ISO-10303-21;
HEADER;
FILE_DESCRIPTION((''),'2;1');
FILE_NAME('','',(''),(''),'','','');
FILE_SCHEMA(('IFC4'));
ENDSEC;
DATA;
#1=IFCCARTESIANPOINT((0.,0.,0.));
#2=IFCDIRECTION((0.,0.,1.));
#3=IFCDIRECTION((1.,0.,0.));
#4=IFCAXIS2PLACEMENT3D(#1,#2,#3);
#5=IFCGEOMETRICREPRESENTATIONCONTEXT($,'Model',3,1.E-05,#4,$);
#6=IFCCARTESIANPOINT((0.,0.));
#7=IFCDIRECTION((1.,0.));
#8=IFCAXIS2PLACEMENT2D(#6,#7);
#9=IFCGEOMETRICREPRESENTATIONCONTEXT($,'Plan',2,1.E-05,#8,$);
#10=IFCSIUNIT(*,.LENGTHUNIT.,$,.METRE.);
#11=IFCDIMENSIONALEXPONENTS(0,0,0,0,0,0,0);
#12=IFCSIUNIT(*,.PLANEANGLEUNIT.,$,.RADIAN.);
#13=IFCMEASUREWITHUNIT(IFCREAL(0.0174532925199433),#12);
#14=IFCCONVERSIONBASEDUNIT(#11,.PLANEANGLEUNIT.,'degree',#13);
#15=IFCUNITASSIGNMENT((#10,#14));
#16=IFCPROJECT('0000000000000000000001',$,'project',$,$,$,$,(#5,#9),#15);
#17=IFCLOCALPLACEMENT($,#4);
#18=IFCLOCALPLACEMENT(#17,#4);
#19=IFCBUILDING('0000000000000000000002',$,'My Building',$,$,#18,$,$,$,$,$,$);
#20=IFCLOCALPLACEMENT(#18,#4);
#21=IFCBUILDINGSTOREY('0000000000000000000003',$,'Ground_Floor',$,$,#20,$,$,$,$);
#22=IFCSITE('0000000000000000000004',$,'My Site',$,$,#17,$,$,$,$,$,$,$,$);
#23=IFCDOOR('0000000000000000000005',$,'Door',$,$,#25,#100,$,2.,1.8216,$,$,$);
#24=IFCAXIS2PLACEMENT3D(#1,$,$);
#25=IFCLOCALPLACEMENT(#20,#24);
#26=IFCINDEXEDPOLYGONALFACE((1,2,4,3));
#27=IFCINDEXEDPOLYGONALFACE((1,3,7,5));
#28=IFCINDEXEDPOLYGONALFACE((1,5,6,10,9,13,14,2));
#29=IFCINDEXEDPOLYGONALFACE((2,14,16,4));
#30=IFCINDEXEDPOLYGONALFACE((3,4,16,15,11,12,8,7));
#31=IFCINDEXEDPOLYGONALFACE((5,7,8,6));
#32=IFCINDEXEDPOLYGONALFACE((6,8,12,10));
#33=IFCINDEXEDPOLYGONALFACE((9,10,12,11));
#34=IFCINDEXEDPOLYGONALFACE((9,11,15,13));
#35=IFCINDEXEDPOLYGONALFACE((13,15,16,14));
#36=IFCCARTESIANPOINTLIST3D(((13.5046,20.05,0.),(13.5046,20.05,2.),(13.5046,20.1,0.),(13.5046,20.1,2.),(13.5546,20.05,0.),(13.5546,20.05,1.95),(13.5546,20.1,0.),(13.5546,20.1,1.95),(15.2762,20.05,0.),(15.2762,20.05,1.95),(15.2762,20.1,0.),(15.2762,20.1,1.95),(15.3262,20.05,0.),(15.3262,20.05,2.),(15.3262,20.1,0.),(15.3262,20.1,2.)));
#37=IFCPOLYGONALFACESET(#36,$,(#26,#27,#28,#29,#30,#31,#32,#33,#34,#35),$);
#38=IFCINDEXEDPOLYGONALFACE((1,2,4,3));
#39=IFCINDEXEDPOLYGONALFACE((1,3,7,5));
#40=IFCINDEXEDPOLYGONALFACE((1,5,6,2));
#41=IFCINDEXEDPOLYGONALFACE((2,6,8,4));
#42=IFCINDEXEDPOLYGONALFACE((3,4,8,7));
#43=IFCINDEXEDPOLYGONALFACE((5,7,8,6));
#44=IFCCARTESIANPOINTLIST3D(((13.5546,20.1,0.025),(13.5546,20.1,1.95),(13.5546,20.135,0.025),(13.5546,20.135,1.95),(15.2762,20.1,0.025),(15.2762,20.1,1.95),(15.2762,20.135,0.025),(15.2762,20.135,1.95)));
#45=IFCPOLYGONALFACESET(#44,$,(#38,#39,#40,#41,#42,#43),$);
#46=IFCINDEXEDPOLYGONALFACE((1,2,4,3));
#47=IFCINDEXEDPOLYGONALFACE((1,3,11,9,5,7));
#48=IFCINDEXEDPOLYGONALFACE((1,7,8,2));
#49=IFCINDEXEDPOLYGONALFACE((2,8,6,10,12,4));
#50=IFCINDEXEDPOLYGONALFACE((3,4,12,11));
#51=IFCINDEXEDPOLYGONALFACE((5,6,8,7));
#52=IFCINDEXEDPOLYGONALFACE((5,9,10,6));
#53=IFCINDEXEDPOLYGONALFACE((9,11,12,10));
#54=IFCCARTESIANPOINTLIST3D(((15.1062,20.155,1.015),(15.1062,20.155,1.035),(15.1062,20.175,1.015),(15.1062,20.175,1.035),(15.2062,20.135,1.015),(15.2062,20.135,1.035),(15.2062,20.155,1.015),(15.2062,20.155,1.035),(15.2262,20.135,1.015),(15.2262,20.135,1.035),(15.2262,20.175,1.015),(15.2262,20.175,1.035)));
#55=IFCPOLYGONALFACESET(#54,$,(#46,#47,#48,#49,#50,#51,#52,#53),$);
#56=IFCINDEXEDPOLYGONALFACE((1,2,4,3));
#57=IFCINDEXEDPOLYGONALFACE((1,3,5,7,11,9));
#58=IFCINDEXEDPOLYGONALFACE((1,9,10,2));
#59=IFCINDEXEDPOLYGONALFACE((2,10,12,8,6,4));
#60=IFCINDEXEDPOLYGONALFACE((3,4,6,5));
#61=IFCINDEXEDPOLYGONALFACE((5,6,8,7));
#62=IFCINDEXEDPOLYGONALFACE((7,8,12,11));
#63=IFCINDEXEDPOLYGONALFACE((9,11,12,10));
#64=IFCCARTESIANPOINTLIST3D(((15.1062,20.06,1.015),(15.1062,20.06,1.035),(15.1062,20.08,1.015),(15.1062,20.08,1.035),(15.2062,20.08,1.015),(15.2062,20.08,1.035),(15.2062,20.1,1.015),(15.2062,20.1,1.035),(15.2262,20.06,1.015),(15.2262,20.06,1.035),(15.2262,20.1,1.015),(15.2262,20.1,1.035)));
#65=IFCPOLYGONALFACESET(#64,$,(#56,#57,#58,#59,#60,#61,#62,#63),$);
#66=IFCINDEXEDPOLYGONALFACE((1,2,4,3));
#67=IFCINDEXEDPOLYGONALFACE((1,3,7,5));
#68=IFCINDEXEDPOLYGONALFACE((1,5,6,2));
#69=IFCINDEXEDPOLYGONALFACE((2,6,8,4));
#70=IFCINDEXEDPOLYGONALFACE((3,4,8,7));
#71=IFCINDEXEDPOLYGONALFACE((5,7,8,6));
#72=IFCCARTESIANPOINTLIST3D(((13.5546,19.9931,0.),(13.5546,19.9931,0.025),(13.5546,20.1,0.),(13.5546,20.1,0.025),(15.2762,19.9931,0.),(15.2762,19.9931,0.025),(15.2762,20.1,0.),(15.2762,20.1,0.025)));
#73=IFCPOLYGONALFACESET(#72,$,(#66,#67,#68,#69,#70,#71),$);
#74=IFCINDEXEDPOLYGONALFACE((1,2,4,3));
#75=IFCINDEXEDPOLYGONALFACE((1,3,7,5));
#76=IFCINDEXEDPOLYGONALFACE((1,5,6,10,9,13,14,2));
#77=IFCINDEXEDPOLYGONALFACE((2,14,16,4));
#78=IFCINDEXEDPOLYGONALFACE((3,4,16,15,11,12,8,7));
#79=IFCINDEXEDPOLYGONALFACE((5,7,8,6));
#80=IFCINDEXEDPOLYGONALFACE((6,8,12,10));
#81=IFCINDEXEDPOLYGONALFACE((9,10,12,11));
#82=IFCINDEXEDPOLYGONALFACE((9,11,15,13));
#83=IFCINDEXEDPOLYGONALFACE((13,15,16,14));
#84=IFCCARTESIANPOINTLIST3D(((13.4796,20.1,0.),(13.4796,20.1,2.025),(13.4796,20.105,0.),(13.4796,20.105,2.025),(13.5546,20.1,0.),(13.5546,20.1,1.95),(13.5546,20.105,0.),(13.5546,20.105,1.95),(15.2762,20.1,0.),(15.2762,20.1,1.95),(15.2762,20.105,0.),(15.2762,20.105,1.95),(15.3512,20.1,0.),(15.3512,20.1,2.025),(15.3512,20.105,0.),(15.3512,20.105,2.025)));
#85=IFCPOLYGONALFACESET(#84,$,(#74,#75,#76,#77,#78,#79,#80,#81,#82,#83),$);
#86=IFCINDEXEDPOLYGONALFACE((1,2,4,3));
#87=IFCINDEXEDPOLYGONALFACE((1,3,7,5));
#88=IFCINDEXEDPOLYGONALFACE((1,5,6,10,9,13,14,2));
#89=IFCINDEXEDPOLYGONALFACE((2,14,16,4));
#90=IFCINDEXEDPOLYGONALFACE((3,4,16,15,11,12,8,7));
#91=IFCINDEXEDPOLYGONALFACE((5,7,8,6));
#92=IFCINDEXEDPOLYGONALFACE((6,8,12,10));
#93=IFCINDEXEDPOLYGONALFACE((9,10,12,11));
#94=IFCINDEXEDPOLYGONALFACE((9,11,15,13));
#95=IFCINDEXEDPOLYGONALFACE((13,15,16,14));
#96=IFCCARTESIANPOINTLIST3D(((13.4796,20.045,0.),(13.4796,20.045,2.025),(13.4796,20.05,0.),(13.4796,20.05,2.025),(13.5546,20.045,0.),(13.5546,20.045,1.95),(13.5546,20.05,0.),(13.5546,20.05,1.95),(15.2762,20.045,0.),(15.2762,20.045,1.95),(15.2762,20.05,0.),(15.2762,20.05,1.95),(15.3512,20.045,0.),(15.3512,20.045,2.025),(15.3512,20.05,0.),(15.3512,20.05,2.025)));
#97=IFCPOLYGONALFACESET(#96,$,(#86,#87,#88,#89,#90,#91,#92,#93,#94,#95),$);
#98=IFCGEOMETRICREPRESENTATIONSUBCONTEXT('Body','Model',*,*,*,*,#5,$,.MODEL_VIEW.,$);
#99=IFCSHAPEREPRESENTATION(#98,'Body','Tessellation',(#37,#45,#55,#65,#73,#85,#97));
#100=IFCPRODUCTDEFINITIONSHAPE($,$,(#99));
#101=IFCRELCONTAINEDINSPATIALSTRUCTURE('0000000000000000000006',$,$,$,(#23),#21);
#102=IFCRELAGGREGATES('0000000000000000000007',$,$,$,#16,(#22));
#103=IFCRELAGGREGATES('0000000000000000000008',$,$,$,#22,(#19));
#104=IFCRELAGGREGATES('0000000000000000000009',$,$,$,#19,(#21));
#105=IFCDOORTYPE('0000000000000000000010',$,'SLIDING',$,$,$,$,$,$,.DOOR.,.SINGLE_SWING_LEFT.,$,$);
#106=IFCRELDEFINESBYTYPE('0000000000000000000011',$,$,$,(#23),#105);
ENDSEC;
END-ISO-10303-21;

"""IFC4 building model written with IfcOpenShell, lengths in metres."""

from ifc_helpers import new_model, entity, si_unit, converted_unit, frame, origin_with_axes, origin_2d_with_axis, place, context, subcontext, project, spatial, line, indexed_curve, outline, extrude, shape, source, transform, mapped, type_object, type_shapes, element, save


model = new_model("IFC4")

# Units and contexts
model_context = context("Model", 3, precision=1e-05, world=origin_with_axes())
plan_context = context("Plan", 2, precision=1e-05, world=origin_2d_with_axis())
body_context_1 = subcontext(model_context, "Body", "Model", "MODEL_VIEW")
body_context_2 = subcontext(plan_context, "Body", "Plan", "PLAN_VIEW")
ifc_project = project(units=[si_unit("LENGTHUNIT", "METRE"), converted_unit("PLANEANGLEUNIT", "degree", entity("IfcReal", 0.0174532925199433), si_unit("PLANEANGLEUNIT", "RADIAN"), dimensions=[0, 0, 0, 0, 0, 0, 0])], contexts=[model_context, plan_context])

# Site, building, storey
site_placement = place(None, origin_with_axes())
site = spatial("IfcSite", under=ifc_project, at=site_placement, Name="My Site")
building_placement = place(site_placement, origin_with_axes())
building = spatial("IfcBuilding", under=site, at=building_placement, Name="My Building")
storey_placement = place(building_placement, origin_with_axes())
storey = spatial("IfcBuildingStorey", under=building, at=storey_placement, Name="Ground_Floor")

# Door
door_type_1 = type_object("IfcDoorType", Name="SLIDING", OperationType="SINGLE_SWING_LEFT", PredefinedType="DOOR")
shared_shape_1 = source(origin_with_axes(), body_context_1, "Body", "SweptSolid", [
    extrude(outline(indexed_curve([(0.0, 0.0), (0.0, 2.0), (1.8216, 2.0), (1.8216, 0.0), (1.7716, 0.0), (1.7716, 1.95), (0.05, 1.95), (0.05, 0.0)], segments=[line(1, 2, 3, 4, 5, 6, 7, 8, 1)])), frame((0.0, 0.0, 0.0), z_axis=(0.0, -1.0, 0.0), x_axis=(1.0, 0.0, 0.0)), (0.0, 0.0, -1.0), 0.05),
    extrude(outline(indexed_curve([(0.0, 0.0), (1.7216, 0.0), (1.7216, 0.035), (0.0, 0.035)], segments=[line(1, 2, 3, 4, 1)])), frame((0.05, -0.035, 0.025), z_axis=(0.0, 0.0, 1.0), x_axis=(1.0, 0.0, 0.0)), (0.0, 0.0, 1.0), 1.925),
    extrude(outline(indexed_curve([(0.0, 0.0), (0.0, -0.04), (0.12, -0.04), (0.12, -0.02), (0.02, -0.02), (0.02, 0.0)], segments=[line(1, 2, 3, 4, 5, 6, 1)])), frame((0.1, -0.035, 1.015), z_axis=(0.0, 0.0, 1.0), x_axis=(1.0, 0.0, 0.0)), (0.0, 0.0, 1.0), 0.02),
    extrude(outline(indexed_curve([(0.0, 0.0), (0.0, 0.04), (0.12, 0.04), (0.12, 0.02), (0.02, 0.02), (0.02, 0.0)], segments=[line(1, 2, 3, 4, 5, 6, 1)])), frame((0.1, 0.0, 1.015), z_axis=(0.0, 0.0, 1.0), x_axis=(1.0, 0.0, 0.0)), (0.0, 0.0, 1.0), 0.02),
    extrude(outline(indexed_curve([(0.0, 0.0), (1.7216, 0.0), (1.7216, 0.1069), (0.0, 0.1069)], segments=[line(1, 2, 3, 4, 1)])), frame((0.05, 0.0, 0.0), z_axis=(0.0, 0.0, 1.0), x_axis=(1.0, 0.0, 0.0)), (0.0, 0.0, 1.0), 0.025),
    extrude(outline(indexed_curve([(0.0, 0.0), (0.0, 2.025), (1.8716, 2.025), (1.8716, 0.0), (1.7966, 0.0), (1.7966, 1.95), (0.075, 1.95), (0.075, 0.0)], segments=[line(1, 2, 3, 4, 5, 6, 7, 8, 1)])), frame((-0.025, -0.005, 0.0), z_axis=(0.0, -1.0, 0.0), x_axis=(1.0, 0.0, 0.0)), (0.0, 0.0, -1.0), 0.005),
    extrude(outline(indexed_curve([(0.0, 0.0), (0.0, 2.025), (1.8716, 2.025), (1.8716, 0.0), (1.7966, 0.0), (1.7966, 1.95), (0.075, 1.95), (0.075, 0.0)], segments=[line(1, 2, 3, 4, 5, 6, 7, 8, 1)])), frame((-0.025, 0.05, 0.0), z_axis=(0.0, -1.0, 0.0), x_axis=(1.0, 0.0, 0.0)), (0.0, 0.0, -1.0), 0.005),
])
shared_shape_2 = source(origin_with_axes(), body_context_2, "Body", "Curve2D", [
    entity("IfcIndexedPolyCurve", entity("IfcCartesianPointList2D", [[0.0, 0.0], [0.05, 0.0], [0.05, 0.05], [0.0, 0.05]]), [entity("IfcLineIndex", [1, 2, 3, 4, 1])]),
    entity("IfcIndexedPolyCurve", entity("IfcCartesianPointList2D", [[1.8216, 0.0], [1.7716, 0.0], [1.7716, 0.05], [1.8216, 0.05]]), [entity("IfcLineIndex", [1, 2, 3, 4, 1])]),
    entity("IfcIndexedPolyCurve", entity("IfcCartesianPointList2D", [[2.6325, -0.035], [0.9108, -0.035], [0.9108, 0.0], [2.6325, 0.0]]), [entity("IfcLineIndex", [1, 2, 3, 4, 1])]),
])
type_shapes(door_type_1, [shared_shape_1, shared_shape_2])
for number, where, z_axis, x_axis, name in (
    (1, (15.3262, 20.1, 0.0), (0.0, 0.0, 1.0), (-1.0, 0.0, 0.0), "Door"),
):
    element("IfcDoor", number, at=place(storey_placement, frame(where, z_axis=z_axis, x_axis=x_axis)), inside=storey, type_object=door_type_1, Name=name, OverallHeight=2.0, OverallWidth=1.8216, shapes=[
        shape(body_context_1, "Body", "MappedRepresentation", [mapped(shared_shape_1, transform((0.0, 0.0, 0.0), x_axis=(1.0, 0.0, 0.0), y_axis=(0.0, 1.0, 0.0), z_axis=(0.0, 0.0, 1.0), scale=1.0))]),
        shape(body_context_2, "Body", "MappedRepresentation", [mapped(shared_shape_2, transform((0.0, 0.0, 0.0), x_axis=(1.0, 0.0, 0.0), y_axis=(0.0, 1.0, 0.0), z_axis=(0.0, 0.0, 1.0), scale=1.0))]),
    ])

save(model, "model.ifc")
